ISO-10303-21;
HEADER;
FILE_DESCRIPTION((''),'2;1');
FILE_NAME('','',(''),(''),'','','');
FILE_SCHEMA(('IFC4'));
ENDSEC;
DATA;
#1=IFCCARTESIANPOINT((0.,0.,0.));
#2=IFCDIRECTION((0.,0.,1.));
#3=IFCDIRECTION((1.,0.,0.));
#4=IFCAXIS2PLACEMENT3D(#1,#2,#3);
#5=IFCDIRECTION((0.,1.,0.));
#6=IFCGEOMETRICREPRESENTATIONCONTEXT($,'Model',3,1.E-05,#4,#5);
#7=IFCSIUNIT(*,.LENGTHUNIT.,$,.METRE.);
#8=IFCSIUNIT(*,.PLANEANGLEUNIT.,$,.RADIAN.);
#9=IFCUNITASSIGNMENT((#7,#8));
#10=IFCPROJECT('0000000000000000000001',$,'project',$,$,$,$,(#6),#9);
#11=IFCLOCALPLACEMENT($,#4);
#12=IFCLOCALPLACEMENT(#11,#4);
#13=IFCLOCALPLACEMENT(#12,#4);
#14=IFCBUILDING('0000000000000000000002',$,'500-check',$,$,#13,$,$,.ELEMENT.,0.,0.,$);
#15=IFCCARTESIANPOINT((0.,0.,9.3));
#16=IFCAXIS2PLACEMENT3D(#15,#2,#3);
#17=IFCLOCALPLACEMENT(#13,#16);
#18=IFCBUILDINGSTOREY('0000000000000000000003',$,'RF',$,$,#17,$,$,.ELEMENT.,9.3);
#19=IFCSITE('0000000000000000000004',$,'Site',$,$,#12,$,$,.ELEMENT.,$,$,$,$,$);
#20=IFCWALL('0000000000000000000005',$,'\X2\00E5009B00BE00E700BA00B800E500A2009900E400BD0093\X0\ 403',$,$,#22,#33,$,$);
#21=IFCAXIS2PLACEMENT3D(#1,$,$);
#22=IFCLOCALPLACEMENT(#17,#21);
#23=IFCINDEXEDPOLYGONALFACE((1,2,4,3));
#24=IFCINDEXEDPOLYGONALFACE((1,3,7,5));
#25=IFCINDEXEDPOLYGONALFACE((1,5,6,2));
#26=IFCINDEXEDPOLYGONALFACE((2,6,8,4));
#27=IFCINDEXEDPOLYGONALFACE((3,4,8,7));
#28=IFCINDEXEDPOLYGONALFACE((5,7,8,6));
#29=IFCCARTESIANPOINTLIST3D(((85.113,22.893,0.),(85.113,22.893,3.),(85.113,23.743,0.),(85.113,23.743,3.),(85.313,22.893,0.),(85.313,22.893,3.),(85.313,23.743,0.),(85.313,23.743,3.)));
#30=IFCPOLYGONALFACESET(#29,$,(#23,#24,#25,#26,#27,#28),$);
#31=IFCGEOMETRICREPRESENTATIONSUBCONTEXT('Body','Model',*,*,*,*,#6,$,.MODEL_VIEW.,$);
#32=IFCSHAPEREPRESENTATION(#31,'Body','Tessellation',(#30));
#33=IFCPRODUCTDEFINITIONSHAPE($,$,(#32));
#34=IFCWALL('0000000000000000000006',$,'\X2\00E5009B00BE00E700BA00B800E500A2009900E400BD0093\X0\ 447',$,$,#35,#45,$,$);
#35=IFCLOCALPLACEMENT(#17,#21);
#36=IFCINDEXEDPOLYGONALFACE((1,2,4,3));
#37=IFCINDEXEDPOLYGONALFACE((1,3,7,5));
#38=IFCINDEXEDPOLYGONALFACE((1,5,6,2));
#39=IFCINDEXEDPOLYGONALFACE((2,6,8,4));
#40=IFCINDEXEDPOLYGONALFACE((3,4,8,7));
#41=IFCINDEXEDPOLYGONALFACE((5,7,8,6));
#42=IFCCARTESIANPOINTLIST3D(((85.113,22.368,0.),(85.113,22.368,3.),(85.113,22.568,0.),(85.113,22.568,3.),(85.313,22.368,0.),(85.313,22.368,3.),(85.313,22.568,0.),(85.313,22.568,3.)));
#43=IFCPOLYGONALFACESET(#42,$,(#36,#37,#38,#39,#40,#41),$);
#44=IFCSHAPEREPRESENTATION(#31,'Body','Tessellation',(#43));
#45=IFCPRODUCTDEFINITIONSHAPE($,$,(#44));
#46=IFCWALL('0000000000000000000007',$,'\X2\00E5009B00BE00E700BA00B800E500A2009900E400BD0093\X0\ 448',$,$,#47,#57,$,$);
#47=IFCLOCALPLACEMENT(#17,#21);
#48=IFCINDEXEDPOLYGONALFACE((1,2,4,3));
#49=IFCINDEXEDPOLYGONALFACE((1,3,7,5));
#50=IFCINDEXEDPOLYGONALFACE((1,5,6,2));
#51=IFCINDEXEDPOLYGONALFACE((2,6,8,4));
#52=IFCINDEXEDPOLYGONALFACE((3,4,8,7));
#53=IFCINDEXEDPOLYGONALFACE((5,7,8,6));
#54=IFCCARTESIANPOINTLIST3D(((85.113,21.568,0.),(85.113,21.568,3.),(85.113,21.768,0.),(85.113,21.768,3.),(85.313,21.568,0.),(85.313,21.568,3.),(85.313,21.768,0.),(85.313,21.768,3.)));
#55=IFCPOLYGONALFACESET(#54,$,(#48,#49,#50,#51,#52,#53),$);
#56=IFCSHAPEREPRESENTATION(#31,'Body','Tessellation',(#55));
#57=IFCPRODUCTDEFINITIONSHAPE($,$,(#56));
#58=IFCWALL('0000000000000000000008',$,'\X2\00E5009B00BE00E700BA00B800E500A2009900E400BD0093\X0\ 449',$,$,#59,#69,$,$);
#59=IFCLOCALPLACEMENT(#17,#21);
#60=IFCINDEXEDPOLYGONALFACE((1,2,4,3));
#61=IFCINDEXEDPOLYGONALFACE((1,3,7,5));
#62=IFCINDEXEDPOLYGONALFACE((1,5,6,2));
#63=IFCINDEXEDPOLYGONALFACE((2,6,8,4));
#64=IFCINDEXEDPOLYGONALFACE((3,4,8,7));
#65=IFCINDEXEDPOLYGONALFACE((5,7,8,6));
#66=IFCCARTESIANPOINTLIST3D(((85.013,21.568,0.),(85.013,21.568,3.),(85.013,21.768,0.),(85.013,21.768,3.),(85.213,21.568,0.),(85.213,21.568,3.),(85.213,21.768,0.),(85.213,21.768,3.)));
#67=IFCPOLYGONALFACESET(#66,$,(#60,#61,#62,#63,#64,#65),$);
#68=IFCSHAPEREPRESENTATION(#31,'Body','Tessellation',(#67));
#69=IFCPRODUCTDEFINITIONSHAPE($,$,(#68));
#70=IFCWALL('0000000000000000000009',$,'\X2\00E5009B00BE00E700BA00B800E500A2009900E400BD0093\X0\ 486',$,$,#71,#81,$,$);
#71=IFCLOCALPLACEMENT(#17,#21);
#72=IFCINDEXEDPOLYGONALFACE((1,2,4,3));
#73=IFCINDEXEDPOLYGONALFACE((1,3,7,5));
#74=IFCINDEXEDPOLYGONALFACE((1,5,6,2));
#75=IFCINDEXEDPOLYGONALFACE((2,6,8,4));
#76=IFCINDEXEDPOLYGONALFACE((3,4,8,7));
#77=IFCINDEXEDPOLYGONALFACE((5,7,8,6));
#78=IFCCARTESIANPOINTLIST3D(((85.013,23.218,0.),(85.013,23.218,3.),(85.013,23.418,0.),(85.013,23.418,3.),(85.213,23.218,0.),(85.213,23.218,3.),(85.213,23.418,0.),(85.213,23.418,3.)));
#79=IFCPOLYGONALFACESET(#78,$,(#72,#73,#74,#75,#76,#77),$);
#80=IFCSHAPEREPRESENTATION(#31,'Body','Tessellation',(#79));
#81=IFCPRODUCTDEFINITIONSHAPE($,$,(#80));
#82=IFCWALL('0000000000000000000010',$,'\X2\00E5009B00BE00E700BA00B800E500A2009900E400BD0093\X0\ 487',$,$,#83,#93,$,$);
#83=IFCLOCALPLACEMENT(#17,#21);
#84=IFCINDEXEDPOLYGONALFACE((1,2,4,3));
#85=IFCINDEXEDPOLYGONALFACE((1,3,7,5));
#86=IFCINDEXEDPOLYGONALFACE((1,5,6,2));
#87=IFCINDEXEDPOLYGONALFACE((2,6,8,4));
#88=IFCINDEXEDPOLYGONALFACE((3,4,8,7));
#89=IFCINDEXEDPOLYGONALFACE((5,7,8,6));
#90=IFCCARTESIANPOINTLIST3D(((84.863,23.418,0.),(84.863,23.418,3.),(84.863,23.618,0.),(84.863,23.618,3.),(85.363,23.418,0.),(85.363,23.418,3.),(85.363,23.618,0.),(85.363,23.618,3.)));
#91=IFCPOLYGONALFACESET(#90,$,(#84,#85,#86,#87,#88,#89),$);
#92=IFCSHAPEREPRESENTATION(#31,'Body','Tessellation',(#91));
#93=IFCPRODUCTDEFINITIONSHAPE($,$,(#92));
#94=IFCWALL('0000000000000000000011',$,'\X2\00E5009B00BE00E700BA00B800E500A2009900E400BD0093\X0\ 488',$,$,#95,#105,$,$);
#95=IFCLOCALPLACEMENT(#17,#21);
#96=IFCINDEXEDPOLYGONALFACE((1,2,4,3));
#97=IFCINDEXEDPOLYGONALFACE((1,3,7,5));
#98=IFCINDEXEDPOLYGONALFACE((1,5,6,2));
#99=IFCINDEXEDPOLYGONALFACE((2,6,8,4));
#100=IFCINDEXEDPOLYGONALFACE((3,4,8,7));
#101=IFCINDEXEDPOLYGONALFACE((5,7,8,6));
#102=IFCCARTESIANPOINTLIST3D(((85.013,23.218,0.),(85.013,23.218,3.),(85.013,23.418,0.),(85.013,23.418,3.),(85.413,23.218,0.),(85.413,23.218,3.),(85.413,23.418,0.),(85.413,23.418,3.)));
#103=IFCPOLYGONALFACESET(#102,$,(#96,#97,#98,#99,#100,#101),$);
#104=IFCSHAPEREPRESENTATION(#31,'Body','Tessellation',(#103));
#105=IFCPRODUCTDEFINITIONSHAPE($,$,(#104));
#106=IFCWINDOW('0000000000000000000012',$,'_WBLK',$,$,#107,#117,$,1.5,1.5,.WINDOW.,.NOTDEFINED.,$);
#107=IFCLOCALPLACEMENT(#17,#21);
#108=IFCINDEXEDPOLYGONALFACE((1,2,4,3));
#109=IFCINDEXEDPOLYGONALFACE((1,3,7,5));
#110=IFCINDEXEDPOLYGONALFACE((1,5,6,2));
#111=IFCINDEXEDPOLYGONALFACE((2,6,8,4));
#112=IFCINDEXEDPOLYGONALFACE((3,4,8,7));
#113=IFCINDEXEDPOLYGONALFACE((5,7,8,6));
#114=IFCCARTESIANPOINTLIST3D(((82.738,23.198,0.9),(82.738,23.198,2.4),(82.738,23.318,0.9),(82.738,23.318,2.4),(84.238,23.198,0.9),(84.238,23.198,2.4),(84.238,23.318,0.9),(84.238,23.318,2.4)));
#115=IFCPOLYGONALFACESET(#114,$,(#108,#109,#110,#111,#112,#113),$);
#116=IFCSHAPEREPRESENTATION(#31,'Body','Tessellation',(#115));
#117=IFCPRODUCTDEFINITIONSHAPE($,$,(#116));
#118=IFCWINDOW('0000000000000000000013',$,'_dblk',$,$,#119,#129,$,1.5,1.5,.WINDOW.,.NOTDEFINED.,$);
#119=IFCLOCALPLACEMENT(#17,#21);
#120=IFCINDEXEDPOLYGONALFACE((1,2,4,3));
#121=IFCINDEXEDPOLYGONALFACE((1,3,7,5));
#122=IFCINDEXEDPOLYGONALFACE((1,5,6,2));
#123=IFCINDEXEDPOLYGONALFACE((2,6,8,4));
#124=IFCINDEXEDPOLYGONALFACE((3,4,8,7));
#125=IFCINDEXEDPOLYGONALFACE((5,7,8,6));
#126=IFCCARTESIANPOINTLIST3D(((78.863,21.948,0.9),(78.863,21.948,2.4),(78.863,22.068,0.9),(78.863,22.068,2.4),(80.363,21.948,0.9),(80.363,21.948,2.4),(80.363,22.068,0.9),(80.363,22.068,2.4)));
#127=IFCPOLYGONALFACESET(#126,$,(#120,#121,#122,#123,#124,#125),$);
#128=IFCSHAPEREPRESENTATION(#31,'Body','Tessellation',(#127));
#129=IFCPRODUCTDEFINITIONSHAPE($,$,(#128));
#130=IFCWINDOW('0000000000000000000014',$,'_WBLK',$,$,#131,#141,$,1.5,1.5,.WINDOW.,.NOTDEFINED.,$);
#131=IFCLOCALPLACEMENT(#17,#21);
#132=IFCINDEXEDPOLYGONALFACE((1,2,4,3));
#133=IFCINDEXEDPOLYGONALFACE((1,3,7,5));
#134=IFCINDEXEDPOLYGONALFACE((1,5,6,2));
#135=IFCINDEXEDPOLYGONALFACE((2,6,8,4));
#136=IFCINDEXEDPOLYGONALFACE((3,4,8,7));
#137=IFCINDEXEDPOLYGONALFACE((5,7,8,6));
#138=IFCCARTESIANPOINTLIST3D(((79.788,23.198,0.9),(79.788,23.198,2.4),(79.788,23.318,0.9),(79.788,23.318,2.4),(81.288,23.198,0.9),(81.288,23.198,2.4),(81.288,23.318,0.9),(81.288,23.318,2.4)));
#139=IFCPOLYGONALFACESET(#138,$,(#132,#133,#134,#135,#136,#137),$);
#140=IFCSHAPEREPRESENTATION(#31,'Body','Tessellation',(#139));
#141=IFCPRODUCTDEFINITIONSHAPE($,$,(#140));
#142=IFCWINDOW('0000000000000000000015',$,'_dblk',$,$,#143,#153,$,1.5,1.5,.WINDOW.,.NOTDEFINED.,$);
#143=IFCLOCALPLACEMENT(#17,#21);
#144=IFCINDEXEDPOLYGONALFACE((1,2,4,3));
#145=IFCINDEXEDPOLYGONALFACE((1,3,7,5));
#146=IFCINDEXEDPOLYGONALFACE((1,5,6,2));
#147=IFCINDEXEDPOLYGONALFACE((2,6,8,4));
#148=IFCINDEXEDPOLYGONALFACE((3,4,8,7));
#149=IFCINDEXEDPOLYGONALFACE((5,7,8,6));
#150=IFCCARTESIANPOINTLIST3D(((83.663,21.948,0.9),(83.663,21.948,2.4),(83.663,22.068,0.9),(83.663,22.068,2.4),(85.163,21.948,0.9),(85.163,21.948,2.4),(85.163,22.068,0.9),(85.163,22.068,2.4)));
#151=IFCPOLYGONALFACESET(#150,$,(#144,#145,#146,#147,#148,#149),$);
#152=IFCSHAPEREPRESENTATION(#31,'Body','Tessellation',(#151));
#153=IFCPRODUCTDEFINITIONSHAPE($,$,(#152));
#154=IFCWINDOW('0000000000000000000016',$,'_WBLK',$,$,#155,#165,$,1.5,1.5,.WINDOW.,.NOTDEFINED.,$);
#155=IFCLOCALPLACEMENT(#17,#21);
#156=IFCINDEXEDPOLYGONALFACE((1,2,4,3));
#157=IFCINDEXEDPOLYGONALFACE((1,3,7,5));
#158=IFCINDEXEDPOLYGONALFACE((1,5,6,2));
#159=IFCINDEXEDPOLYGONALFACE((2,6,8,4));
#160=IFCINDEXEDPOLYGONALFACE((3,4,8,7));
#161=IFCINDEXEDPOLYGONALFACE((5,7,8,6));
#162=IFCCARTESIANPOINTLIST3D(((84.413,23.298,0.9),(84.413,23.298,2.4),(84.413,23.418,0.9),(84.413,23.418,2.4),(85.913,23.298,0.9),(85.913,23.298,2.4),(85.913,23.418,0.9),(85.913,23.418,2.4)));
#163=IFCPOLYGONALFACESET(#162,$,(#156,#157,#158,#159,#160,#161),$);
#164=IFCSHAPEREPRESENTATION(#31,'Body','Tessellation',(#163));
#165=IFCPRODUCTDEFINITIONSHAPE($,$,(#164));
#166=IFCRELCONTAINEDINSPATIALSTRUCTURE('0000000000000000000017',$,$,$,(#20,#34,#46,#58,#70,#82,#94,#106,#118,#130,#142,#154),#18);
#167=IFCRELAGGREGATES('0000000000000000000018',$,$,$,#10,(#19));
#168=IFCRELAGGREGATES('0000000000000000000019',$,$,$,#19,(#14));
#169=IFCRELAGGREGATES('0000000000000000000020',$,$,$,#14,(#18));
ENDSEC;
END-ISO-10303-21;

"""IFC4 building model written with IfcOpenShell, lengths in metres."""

from ifc_helpers import new_model, si_unit, direction, frame, frame_2d, origin_with_axes, place, context, subcontext, project, spatial, rectangle, extrude, element, save


model = new_model("IFC4")

# Units and contexts
model_context = context("Model", 3, precision=1e-05, world=origin_with_axes(), true_north=direction((0.0, 1.0, 0.0)))
body_context = subcontext(model_context, "Body", "Model", "MODEL_VIEW")
ifc_project = project(units=[si_unit("LENGTHUNIT", "METRE"), si_unit("PLANEANGLEUNIT", "RADIAN")], contexts=[model_context])

# Site, building, storey
placement = place(None, origin_with_axes())
site_placement = place(placement, origin_with_axes())
site = spatial("IfcSite", under=ifc_project, at=site_placement, Name="Site", CompositionType="ELEMENT")
building_placement = place(site_placement, origin_with_axes())
building = spatial("IfcBuilding", under=site, at=building_placement, Name="500-check", CompositionType="ELEMENT", ElevationOfRefHeight=0.0, ElevationOfTerrain=0.0)
storey_placement = place(building_placement, frame((0.0, 0.0, 9.3), z_axis=(0.0, 0.0, 1.0), x_axis=(1.0, 0.0, 0.0)))
storey = spatial("IfcBuildingStorey", under=building, at=storey_placement, Name="RF", CompositionType="ELEMENT", Elevation=9.3)

# Walls
for number, where, z_axis, x_axis, name in (
    (1, (85.213, 23.318, 0.0), (0.0, 0.0, 1.0), (0.0, -1.0, 0.0), "å\u009b¾çº¸å¢\u0099ä½\u0093 403"),
):
    element("IfcWall", number, at=place(storey_placement, frame(where, z_axis=z_axis, x_axis=x_axis)), inside=storey, Name=name, context=body_context, shape_type="SweptSolid", body=[
        extrude(rectangle(XDim=0.85, YDim=0.2, at=frame_2d((0.0, 0.0), x_axis=(1.0, 0.0, 0.0))), frame((0.0, 0.0, 0.0), z_axis=(0.0, 0.0, 1.0)), (0.0, 0.0, 1.0), 3.0),
    ])
for number, where, z_axis, x_axis, name in (
    (2, (85.213, 22.468, 0.0), (0.0, 0.0, 1.0), (-1.0, 0.0, 0.0), "å\u009b¾çº¸å¢\u0099ä½\u0093 447"),
    (3, (85.213, 21.668, 0.0), (0.0, 0.0, 1.0), (-1.0, 0.0, 0.0), "å\u009b¾çº¸å¢\u0099ä½\u0093 448"),
    (4, (85.113, 21.668, 0.0), (0.0, 0.0, 1.0), (0.0, -1.0, 0.0), "å\u009b¾çº¸å¢\u0099ä½\u0093 449"),
    (5, (85.113, 23.318, 0.0), (0.0, 0.0, 1.0), (0.0, 1.0, 0.0), "å\u009b¾çº¸å¢\u0099ä½\u0093 486"),
):
    element("IfcWall", number, at=place(storey_placement, frame(where, z_axis=z_axis, x_axis=x_axis)), inside=storey, Name=name, context=body_context, shape_type="SweptSolid", body=[
        extrude(rectangle(XDim=0.2, YDim=0.2, at=frame_2d((0.0, 0.0), x_axis=(1.0, 0.0, 0.0))), frame((0.0, 0.0, 0.0), z_axis=(0.0, 0.0, 1.0)), (0.0, 0.0, 1.0), 3.0),
    ])
wall_1_placement = place(storey_placement, frame((85.113, 23.518, 0.0), z_axis=(0.0, 0.0, 1.0), x_axis=(1.0, 0.0, 0.0)))
element("IfcWall", 6, at=wall_1_placement, inside=storey, Name="å\u009b¾çº¸å¢\u0099ä½\u0093 487", context=body_context, shape_type="SweptSolid", body=[
    extrude(rectangle(XDim=0.5, YDim=0.2, at=frame_2d((0.0, 0.0), x_axis=(1.0, 0.0, 0.0))), frame((0.0, 0.0, 0.0), z_axis=(0.0, 0.0, 1.0)), (0.0, 0.0, 1.0), 3.0),
])
wall_2_placement = place(storey_placement, frame((85.213, 23.318, 0.0), z_axis=(0.0, 0.0, 1.0), x_axis=(1.0, 0.0, 0.0)))
element("IfcWall", 7, at=wall_2_placement, inside=storey, Name="å\u009b¾çº¸å¢\u0099ä½\u0093 488", context=body_context, shape_type="SweptSolid", body=[
    extrude(rectangle(XDim=0.4, YDim=0.2, at=frame_2d((0.0, 0.0), x_axis=(1.0, 0.0, 0.0))), frame((0.0, 0.0, 0.0), z_axis=(0.0, 0.0, 1.0)), (0.0, 0.0, 1.0), 3.0),
])

# Windows
for number, where, z_axis, x_axis, name in (
    (8, (83.488, 23.258, 0.9), (0.0, 0.0, 1.0), (1.0, 0.0, 0.0), "_WBLK"),
    (9, (79.613, 22.008, 0.9), (0.0, 0.0, 1.0), (1.0, 0.0, 0.0), "_dblk"),
    (10, (80.538, 23.258, 0.9), (0.0, 0.0, 1.0), (1.0, 0.0, 0.0), "_WBLK"),
    (11, (84.413, 22.008, 0.9), (0.0, 0.0, 1.0), (1.0, 0.0, 0.0), "_dblk"),
    (12, (85.163, 23.358, 0.9), (0.0, 0.0, 1.0), (1.0, 0.0, 0.0), "_WBLK"),
):
    element("IfcWindow", number, at=place(storey_placement, frame(where, z_axis=z_axis, x_axis=x_axis)), inside=storey, Name=name, OverallHeight=1.5, OverallWidth=1.5, PartitioningType="NOTDEFINED", PredefinedType="WINDOW", context=body_context, shape_type="SweptSolid", body=[
        extrude(rectangle(XDim=1.5, YDim=0.12, at=frame_2d((0.0, 0.0), x_axis=(1.0, 0.0, 0.0))), frame((0.0, 0.0, 0.0), z_axis=(0.0, 0.0, 1.0)), (0.0, 0.0, 1.0), 1.5),
    ])

save(model, "model.ifc")
